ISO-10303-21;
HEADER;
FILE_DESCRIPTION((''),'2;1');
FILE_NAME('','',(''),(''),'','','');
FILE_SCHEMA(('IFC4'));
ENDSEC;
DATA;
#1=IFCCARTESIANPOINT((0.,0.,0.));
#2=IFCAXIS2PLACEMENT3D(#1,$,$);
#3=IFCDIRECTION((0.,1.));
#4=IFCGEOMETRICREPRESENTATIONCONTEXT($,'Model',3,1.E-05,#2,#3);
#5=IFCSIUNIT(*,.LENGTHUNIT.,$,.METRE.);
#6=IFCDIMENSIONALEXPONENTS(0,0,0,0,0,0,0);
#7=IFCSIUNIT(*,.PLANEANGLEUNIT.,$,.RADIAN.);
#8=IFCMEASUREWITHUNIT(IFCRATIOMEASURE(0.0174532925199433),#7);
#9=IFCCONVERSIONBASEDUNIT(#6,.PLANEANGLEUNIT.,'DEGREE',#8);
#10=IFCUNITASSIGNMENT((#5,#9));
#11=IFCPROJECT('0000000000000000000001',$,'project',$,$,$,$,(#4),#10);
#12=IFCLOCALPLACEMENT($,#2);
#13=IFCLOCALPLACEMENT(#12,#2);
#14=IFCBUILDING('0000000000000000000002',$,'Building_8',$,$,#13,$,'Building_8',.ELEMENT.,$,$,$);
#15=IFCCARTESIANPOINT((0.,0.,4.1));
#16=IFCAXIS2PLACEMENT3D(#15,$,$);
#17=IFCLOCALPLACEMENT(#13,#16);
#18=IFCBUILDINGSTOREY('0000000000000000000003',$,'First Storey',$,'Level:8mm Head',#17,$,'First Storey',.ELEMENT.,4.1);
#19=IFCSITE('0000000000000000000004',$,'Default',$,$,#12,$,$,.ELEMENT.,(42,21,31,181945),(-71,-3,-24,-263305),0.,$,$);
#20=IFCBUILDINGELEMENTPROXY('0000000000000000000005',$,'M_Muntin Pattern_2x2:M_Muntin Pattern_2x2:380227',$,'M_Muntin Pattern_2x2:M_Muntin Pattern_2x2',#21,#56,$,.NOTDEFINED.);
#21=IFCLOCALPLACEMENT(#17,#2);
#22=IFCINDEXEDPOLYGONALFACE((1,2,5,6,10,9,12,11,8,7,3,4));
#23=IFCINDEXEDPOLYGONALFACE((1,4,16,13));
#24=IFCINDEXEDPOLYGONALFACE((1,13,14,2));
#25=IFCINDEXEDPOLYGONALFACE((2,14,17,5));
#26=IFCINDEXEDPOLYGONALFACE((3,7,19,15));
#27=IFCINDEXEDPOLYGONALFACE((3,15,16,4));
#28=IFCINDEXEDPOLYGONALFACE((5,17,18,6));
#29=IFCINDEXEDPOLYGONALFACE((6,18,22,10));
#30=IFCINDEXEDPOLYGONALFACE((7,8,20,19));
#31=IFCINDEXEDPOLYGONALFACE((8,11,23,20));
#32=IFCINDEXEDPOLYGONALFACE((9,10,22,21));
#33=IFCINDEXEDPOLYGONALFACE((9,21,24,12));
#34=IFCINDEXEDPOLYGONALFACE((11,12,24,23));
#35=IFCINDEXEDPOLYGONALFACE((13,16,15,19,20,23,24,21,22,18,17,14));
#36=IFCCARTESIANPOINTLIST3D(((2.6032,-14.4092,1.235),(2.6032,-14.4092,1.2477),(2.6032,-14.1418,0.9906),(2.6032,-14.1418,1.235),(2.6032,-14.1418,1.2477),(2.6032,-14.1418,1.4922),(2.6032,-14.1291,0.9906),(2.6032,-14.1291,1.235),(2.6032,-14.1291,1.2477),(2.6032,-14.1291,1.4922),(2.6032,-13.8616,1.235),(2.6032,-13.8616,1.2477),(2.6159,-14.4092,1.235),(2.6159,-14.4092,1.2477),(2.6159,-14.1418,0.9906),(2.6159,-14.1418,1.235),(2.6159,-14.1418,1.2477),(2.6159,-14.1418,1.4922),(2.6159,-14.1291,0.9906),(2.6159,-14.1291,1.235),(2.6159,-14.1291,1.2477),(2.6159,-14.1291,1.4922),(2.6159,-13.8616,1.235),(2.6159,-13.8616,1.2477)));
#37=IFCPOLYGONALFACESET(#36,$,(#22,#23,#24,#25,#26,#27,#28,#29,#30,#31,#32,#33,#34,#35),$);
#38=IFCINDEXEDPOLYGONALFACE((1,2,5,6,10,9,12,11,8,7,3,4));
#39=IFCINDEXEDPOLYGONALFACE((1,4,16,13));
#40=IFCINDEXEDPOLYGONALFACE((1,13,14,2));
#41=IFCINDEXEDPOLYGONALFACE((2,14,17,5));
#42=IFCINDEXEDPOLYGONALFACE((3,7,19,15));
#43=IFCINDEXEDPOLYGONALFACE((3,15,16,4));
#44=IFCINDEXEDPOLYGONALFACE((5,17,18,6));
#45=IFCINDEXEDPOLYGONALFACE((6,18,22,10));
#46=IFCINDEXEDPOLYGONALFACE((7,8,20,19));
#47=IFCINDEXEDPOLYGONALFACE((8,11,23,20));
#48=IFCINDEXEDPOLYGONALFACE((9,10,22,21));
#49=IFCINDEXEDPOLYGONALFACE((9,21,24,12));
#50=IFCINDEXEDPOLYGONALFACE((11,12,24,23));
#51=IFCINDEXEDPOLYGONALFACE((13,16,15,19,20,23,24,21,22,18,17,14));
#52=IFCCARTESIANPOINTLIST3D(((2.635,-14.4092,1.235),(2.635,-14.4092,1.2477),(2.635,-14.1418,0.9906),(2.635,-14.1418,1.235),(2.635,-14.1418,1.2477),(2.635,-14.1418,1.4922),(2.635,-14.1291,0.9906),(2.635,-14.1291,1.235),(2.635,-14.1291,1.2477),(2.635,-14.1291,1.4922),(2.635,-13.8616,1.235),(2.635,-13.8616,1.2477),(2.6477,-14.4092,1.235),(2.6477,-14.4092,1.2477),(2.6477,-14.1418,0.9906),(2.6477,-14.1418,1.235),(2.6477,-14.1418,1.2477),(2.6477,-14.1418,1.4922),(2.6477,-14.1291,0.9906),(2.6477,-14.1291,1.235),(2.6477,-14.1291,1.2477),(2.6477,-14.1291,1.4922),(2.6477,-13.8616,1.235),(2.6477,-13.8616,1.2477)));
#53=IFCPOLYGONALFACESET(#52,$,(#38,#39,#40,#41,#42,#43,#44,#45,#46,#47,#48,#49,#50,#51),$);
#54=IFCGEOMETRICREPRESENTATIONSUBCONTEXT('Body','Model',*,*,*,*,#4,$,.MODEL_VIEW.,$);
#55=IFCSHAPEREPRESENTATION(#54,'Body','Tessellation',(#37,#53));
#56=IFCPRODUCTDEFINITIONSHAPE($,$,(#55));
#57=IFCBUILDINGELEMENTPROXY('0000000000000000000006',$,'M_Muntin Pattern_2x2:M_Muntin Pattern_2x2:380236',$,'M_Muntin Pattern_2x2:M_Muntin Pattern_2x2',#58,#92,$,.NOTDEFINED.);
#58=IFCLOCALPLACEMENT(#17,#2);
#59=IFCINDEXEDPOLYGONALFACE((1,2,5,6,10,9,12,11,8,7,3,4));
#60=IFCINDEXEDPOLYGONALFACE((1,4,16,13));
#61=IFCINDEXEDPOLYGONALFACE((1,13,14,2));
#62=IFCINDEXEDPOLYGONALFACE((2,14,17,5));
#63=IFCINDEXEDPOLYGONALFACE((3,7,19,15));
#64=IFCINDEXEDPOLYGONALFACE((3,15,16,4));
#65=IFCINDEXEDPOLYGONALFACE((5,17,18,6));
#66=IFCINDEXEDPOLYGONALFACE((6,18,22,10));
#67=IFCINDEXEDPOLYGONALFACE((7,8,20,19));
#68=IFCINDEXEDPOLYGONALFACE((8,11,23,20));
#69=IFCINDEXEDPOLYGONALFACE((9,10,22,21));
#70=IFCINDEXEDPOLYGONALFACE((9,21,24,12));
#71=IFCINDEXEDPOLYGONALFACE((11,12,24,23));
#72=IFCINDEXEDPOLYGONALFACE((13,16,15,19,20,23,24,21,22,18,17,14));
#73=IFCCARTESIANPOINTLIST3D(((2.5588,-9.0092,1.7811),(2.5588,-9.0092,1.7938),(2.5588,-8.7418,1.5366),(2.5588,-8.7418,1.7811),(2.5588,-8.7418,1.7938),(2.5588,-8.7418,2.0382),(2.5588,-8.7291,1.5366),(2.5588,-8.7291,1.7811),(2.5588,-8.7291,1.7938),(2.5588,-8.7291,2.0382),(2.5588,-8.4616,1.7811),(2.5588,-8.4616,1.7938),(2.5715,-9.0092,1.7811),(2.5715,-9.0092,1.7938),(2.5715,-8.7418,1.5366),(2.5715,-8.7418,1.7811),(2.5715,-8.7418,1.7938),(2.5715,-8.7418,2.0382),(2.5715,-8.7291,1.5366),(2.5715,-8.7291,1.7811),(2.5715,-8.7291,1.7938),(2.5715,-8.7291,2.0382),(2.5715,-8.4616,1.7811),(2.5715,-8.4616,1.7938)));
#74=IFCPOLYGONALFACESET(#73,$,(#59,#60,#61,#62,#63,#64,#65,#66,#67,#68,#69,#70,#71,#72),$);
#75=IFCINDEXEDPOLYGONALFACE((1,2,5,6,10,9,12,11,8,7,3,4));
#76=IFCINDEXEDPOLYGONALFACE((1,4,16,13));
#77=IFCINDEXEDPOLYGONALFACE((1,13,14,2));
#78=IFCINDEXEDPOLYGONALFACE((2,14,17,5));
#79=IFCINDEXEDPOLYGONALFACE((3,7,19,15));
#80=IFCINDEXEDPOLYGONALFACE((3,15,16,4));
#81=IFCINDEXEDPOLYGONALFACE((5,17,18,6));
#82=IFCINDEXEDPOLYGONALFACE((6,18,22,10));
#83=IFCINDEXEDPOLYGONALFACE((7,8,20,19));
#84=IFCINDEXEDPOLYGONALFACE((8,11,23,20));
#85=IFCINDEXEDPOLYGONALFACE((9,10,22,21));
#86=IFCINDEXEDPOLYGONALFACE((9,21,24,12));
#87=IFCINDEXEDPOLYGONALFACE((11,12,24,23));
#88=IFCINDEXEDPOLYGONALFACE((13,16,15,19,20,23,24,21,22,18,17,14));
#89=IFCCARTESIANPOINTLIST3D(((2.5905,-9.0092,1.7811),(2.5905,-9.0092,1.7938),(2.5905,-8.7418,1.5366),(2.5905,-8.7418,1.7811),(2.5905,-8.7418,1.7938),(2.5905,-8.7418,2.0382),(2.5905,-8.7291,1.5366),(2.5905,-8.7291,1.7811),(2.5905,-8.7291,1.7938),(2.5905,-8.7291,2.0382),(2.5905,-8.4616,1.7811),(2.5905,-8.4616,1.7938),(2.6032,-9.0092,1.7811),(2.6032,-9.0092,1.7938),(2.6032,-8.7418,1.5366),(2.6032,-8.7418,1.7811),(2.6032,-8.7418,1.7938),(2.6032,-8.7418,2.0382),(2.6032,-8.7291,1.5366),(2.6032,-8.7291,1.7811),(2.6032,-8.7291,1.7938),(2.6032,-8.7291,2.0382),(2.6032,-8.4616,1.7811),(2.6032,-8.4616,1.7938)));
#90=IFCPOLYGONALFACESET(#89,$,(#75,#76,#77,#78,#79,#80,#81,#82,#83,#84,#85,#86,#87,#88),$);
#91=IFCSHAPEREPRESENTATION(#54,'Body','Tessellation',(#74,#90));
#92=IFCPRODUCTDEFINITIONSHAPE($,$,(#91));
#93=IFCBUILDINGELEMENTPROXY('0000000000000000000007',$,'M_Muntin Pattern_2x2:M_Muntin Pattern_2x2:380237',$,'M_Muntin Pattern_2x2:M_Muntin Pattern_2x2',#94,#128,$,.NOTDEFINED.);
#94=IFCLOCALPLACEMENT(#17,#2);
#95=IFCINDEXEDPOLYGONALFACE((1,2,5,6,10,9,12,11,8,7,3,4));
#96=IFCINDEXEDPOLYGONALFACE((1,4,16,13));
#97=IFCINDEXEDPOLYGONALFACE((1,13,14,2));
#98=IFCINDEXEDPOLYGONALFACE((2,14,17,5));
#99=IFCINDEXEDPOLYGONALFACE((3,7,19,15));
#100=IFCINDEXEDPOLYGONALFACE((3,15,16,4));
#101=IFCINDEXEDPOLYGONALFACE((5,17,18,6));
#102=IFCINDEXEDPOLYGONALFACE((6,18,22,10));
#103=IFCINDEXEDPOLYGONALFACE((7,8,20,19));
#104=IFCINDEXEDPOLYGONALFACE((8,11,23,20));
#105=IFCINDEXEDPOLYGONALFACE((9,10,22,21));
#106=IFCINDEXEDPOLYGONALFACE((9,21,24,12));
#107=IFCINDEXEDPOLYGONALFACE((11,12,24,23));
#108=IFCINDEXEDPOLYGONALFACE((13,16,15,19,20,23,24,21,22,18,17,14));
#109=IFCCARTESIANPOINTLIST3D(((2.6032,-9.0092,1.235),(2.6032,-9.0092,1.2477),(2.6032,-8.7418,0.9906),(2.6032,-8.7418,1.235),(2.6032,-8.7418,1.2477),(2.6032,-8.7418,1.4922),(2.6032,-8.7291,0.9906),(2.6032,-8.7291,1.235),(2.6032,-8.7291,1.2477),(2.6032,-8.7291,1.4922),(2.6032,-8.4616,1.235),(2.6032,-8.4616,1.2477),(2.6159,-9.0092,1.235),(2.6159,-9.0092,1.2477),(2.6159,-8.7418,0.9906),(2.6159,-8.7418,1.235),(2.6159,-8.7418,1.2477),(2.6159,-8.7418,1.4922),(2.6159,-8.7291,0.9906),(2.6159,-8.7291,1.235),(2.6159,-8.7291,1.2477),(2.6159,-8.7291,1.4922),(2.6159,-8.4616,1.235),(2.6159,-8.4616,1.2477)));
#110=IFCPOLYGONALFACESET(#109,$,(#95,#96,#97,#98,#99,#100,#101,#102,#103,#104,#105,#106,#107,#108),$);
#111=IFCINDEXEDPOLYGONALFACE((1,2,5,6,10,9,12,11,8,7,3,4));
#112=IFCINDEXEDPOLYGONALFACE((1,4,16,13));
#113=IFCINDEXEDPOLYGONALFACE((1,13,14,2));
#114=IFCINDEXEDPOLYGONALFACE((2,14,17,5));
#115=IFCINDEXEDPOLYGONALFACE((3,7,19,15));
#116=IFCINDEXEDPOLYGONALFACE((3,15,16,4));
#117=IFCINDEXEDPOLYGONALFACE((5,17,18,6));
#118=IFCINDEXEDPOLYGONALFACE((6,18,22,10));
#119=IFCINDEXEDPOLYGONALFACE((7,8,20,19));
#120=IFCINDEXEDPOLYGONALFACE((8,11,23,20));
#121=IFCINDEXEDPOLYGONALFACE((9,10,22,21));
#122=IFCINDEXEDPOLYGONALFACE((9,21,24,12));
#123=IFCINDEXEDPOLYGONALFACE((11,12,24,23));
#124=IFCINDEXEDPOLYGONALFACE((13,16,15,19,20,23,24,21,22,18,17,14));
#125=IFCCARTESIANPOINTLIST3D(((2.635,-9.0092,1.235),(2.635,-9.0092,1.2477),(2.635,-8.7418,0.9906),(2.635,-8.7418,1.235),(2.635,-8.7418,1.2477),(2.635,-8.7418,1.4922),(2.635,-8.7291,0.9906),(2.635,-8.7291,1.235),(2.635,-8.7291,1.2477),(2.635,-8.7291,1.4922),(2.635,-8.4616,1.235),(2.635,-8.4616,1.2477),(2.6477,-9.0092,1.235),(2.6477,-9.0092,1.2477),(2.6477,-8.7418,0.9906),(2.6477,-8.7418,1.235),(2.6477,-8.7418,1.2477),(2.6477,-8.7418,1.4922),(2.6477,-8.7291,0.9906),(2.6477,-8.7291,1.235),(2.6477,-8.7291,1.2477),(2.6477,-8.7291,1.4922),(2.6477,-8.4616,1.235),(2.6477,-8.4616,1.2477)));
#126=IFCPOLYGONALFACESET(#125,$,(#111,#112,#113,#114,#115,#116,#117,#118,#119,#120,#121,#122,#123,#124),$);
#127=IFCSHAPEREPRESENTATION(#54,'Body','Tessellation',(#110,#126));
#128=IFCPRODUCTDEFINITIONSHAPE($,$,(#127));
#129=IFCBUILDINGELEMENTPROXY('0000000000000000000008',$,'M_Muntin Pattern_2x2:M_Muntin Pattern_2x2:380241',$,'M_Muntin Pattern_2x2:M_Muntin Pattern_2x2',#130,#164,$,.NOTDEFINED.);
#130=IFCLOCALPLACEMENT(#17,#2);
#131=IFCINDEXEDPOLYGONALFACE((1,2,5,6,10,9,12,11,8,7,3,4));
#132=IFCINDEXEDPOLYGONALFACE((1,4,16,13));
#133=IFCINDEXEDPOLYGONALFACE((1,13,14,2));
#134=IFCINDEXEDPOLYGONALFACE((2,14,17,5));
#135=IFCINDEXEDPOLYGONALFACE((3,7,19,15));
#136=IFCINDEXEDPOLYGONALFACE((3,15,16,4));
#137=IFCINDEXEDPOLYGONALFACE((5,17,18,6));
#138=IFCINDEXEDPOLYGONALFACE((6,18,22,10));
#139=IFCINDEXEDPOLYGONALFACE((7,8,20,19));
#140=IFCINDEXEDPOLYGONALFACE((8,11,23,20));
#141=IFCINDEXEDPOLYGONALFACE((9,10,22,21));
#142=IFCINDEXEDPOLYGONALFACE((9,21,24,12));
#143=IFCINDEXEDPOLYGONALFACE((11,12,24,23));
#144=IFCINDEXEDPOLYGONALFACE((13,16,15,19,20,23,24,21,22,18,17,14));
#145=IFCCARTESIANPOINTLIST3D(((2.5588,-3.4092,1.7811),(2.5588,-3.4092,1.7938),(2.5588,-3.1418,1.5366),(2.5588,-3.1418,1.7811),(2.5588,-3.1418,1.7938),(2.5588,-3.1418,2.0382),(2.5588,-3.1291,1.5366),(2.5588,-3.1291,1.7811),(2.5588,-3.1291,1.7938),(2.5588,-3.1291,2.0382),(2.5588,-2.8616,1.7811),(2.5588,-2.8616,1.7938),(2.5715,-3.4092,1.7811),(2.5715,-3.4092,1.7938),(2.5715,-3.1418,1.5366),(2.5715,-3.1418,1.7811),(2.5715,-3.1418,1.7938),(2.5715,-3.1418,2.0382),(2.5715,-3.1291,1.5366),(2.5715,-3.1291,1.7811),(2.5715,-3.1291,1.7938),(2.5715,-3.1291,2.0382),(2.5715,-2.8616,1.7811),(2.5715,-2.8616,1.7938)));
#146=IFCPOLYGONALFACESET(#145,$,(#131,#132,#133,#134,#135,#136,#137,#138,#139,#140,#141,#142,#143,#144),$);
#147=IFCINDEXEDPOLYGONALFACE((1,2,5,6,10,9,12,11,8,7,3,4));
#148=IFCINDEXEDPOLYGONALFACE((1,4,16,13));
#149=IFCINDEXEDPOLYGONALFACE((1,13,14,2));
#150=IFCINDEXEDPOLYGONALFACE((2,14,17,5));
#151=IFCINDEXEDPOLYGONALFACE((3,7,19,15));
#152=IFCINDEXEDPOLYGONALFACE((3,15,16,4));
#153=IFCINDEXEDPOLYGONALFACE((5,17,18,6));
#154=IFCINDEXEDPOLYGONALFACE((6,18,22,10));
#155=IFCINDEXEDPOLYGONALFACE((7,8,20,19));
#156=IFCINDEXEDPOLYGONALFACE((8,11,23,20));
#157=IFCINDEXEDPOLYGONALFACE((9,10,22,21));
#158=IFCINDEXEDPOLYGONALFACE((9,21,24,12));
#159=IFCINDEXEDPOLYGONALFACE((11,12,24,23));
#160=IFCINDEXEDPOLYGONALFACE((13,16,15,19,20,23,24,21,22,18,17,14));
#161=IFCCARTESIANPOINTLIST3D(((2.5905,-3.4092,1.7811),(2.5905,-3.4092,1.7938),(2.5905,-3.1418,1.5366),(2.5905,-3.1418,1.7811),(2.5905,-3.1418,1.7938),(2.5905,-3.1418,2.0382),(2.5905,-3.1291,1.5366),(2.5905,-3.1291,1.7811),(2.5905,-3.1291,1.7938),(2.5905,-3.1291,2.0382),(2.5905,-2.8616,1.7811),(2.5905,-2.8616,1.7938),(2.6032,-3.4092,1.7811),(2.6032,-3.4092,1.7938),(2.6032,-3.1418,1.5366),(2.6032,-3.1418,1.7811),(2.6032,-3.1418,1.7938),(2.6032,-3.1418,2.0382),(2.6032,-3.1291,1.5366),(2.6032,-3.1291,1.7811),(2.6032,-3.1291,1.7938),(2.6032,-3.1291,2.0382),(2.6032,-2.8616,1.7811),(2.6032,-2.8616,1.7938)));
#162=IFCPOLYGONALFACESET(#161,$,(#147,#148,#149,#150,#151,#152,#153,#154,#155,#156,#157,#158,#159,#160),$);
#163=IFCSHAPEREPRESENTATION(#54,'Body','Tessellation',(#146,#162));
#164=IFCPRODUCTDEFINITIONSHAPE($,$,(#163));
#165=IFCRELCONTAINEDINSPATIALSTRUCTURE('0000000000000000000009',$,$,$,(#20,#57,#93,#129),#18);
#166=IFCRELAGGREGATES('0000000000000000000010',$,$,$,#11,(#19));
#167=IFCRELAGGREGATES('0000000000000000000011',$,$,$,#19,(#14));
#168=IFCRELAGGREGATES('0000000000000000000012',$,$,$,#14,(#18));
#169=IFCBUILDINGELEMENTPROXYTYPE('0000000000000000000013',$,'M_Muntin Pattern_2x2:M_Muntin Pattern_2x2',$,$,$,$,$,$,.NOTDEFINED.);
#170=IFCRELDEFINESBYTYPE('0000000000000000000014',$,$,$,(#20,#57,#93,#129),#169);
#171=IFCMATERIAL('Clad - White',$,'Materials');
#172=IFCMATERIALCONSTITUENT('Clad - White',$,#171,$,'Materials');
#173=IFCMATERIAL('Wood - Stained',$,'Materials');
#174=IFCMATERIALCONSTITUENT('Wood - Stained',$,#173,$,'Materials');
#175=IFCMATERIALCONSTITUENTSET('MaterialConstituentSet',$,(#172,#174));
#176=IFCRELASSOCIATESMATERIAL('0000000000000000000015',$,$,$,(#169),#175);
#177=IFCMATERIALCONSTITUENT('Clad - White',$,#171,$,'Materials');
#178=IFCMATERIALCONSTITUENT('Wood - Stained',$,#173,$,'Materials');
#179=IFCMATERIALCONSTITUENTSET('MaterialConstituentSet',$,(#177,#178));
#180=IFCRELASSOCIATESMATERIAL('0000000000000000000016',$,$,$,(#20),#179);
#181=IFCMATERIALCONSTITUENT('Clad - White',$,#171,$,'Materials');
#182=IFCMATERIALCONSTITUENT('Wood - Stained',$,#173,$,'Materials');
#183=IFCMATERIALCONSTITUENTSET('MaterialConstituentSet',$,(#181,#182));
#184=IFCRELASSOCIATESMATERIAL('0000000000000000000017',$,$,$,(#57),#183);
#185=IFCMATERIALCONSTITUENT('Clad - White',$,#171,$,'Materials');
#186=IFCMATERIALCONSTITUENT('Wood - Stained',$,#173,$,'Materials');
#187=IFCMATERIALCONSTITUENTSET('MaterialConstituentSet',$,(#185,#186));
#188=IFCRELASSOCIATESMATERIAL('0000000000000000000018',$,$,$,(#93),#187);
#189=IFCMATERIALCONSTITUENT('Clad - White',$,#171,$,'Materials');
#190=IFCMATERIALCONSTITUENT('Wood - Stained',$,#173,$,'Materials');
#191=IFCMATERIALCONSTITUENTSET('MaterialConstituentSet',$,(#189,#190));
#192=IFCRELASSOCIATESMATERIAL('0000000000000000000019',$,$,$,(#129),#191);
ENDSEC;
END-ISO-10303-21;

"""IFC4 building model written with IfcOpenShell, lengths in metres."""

from ifc_helpers import new_model, entity, si_unit, converted_unit, direction, frame, origin, place, context, subcontext, project, spatial, indexed_curve, outline, extrude, source, transform, mapped, material, constituent, constituent_set, type_object, type_shapes, element, save


model = new_model("IFC4")

# Units and contexts
model_context = context("Model", 3, precision=1e-05, world=origin(), true_north=direction((0.0, 1.0)))
body_context = subcontext(model_context, "Body", "Model", "MODEL_VIEW")
ifc_project = project(units=[si_unit("LENGTHUNIT", "METRE"), converted_unit("PLANEANGLEUNIT", "DEGREE", entity("IfcRatioMeasure", 0.0174532925199433), si_unit("PLANEANGLEUNIT", "RADIAN"), dimensions=[0, 0, 0, 0, 0, 0, 0])], contexts=[model_context])

# Site, building, storey
site_placement = place(None, origin())
site = spatial("IfcSite", under=ifc_project, at=site_placement, Name="Default", CompositionType="ELEMENT", RefLatitude=(42, 21, 31, 181945), RefLongitude=(-71, -3, -24, -263305), RefElevation=0.0)
building_placement = place(site_placement, origin())
building = spatial("IfcBuilding", under=site, at=building_placement, Name="Building_8", LongName="Building_8", CompositionType="ELEMENT")
storey_placement = place(building_placement, frame((0.0, 0.0, 4.1)))
storey = spatial("IfcBuildingStorey", under=building, at=storey_placement, Name="First Storey", ObjectType="Level:8mm Head", LongName="First Storey", CompositionType="ELEMENT", Elevation=4.1)

# Building element proxies
ifc_material_1 = material(Name="Clad - White", Category="Materials")
ifc_material_2 = material(Name="Wood - Stained", Category="Materials")
ifc_constituent_1 = constituent(ifc_material_1, Name="Clad - White", Category="Materials")
ifc_constituent_2 = constituent(ifc_material_2, Name="Wood - Stained", Category="Materials")
ifc_constituent_set_1 = constituent_set(constituents=[ifc_constituent_1, ifc_constituent_2], Name="MaterialConstituentSet")
building_element_proxy_type_1 = type_object("IfcBuildingElementProxyType", Name="M_Muntin Pattern_2x2:M_Muntin Pattern_2x2", PredefinedType="NOTDEFINED", material=ifc_constituent_set_1)
shared_shape_1 = source(origin(), body_context, "Body", "SweptSolid", [
    extrude(outline(indexed_curve([(0.0064, -0.0064), (0.2508, -0.0064), (0.2508, 0.0063), (0.0064, 0.0063), (0.0064, 0.2738), (-0.0063, 0.2738), (-0.0063, 0.0063), (-0.2508, 0.0063), (-0.2508, -0.0064), (-0.0063, -0.0064), (-0.0063, -0.2738), (0.0064, -0.2738), (0.0064, -0.0064)], self_intersect=False)), frame((0.0, 0.0095, 0.2508), z_axis=(0.0, 1.0, 0.0), x_axis=(0.0, 0.0, 1.0)), (0.0, 0.0, 1.0), 0.0127),
    extrude(outline(indexed_curve([(0.0064, -0.0064), (0.2508, -0.0064), (0.2508, 0.0063), (0.0064, 0.0063), (0.0064, 0.2738), (-0.0063, 0.2738), (-0.0063, 0.0063), (-0.2508, 0.0063), (-0.2508, -0.0064), (-0.0063, -0.0064), (-0.0063, -0.2738), (0.0064, -0.2738), (0.0064, -0.0064)], self_intersect=False)), frame((0.0, -0.0222, 0.2508), z_axis=(0.0, 1.0, 0.0), x_axis=(0.0, 0.0, 1.0)), (0.0, 0.0, 1.0), 0.0127),
])
type_shapes(building_element_proxy_type_1, [shared_shape_1])
ifc_constituent_3 = constituent(ifc_material_1, Name="Clad - White", Category="Materials")
ifc_constituent_4 = constituent(ifc_material_2, Name="Wood - Stained", Category="Materials")
ifc_constituent_set_2 = constituent_set(constituents=[ifc_constituent_3, ifc_constituent_4], Name="MaterialConstituentSet")
proxy_1_placement = place(storey_placement, frame((2.6255, -14.1354, 0.9906), z_axis=(0.0, 0.0, 1.0), x_axis=(0.0, 1.0, 0.0)))
element("IfcBuildingElementProxy", 1, at=proxy_1_placement, inside=storey, type_object=building_element_proxy_type_1, material=ifc_constituent_set_2, Name="M_Muntin Pattern_2x2:M_Muntin Pattern_2x2:380227", ObjectType="M_Muntin Pattern_2x2:M_Muntin Pattern_2x2", PredefinedType="NOTDEFINED", context=body_context, shape_type="MappedRepresentation", body=[
    mapped(shared_shape_1, transform((0.0, 0.0, 0.0), scale=1.0)),
])
ifc_constituent_5 = constituent(ifc_material_1, Name="Clad - White", Category="Materials")
ifc_constituent_6 = constituent(ifc_material_2, Name="Wood - Stained", Category="Materials")
ifc_constituent_set_3 = constituent_set(constituents=[ifc_constituent_5, ifc_constituent_6], Name="MaterialConstituentSet")
proxy_2_placement = place(storey_placement, frame((2.581, -8.7354, 1.5366), z_axis=(0.0, 0.0, 1.0), x_axis=(0.0, 1.0, 0.0)))
element("IfcBuildingElementProxy", 2, at=proxy_2_placement, inside=storey, type_object=building_element_proxy_type_1, material=ifc_constituent_set_3, Name="M_Muntin Pattern_2x2:M_Muntin Pattern_2x2:380236", ObjectType="M_Muntin Pattern_2x2:M_Muntin Pattern_2x2", PredefinedType="NOTDEFINED", context=body_context, shape_type="MappedRepresentation", body=[
    mapped(shared_shape_1, transform((0.0, 0.0, 0.0), scale=1.0)),
])
ifc_constituent_7 = constituent(ifc_material_1, Name="Clad - White", Category="Materials")
ifc_constituent_8 = constituent(ifc_material_2, Name="Wood - Stained", Category="Materials")
ifc_constituent_set_4 = constituent_set(constituents=[ifc_constituent_7, ifc_constituent_8], Name="MaterialConstituentSet")
proxy_3_placement = place(storey_placement, frame((2.6255, -8.7354, 0.9906), z_axis=(0.0, 0.0, 1.0), x_axis=(0.0, 1.0, 0.0)))
element("IfcBuildingElementProxy", 3, at=proxy_3_placement, inside=storey, type_object=building_element_proxy_type_1, material=ifc_constituent_set_4, Name="M_Muntin Pattern_2x2:M_Muntin Pattern_2x2:380237", ObjectType="M_Muntin Pattern_2x2:M_Muntin Pattern_2x2", PredefinedType="NOTDEFINED", context=body_context, shape_type="MappedRepresentation", body=[
    mapped(shared_shape_1, transform((0.0, 0.0, 0.0), scale=1.0)),
])
ifc_constituent_9 = constituent(ifc_material_1, Name="Clad - White", Category="Materials")
ifc_constituent_10 = constituent(ifc_material_2, Name="Wood - Stained", Category="Materials")
ifc_constituent_set_5 = constituent_set(constituents=[ifc_constituent_9, ifc_constituent_10], Name="MaterialConstituentSet")
proxy_4_placement = place(storey_placement, frame((2.581, -3.1354, 1.5366), z_axis=(0.0, 0.0, 1.0), x_axis=(0.0, 1.0, 0.0)))
element("IfcBuildingElementProxy", 4, at=proxy_4_placement, inside=storey, type_object=building_element_proxy_type_1, material=ifc_constituent_set_5, Name="M_Muntin Pattern_2x2:M_Muntin Pattern_2x2:380241", ObjectType="M_Muntin Pattern_2x2:M_Muntin Pattern_2x2", PredefinedType="NOTDEFINED", context=body_context, shape_type="MappedRepresentation", body=[
    mapped(shared_shape_1, transform((0.0, 0.0, 0.0), scale=1.0)),
])

save(model, "model.ifc")
